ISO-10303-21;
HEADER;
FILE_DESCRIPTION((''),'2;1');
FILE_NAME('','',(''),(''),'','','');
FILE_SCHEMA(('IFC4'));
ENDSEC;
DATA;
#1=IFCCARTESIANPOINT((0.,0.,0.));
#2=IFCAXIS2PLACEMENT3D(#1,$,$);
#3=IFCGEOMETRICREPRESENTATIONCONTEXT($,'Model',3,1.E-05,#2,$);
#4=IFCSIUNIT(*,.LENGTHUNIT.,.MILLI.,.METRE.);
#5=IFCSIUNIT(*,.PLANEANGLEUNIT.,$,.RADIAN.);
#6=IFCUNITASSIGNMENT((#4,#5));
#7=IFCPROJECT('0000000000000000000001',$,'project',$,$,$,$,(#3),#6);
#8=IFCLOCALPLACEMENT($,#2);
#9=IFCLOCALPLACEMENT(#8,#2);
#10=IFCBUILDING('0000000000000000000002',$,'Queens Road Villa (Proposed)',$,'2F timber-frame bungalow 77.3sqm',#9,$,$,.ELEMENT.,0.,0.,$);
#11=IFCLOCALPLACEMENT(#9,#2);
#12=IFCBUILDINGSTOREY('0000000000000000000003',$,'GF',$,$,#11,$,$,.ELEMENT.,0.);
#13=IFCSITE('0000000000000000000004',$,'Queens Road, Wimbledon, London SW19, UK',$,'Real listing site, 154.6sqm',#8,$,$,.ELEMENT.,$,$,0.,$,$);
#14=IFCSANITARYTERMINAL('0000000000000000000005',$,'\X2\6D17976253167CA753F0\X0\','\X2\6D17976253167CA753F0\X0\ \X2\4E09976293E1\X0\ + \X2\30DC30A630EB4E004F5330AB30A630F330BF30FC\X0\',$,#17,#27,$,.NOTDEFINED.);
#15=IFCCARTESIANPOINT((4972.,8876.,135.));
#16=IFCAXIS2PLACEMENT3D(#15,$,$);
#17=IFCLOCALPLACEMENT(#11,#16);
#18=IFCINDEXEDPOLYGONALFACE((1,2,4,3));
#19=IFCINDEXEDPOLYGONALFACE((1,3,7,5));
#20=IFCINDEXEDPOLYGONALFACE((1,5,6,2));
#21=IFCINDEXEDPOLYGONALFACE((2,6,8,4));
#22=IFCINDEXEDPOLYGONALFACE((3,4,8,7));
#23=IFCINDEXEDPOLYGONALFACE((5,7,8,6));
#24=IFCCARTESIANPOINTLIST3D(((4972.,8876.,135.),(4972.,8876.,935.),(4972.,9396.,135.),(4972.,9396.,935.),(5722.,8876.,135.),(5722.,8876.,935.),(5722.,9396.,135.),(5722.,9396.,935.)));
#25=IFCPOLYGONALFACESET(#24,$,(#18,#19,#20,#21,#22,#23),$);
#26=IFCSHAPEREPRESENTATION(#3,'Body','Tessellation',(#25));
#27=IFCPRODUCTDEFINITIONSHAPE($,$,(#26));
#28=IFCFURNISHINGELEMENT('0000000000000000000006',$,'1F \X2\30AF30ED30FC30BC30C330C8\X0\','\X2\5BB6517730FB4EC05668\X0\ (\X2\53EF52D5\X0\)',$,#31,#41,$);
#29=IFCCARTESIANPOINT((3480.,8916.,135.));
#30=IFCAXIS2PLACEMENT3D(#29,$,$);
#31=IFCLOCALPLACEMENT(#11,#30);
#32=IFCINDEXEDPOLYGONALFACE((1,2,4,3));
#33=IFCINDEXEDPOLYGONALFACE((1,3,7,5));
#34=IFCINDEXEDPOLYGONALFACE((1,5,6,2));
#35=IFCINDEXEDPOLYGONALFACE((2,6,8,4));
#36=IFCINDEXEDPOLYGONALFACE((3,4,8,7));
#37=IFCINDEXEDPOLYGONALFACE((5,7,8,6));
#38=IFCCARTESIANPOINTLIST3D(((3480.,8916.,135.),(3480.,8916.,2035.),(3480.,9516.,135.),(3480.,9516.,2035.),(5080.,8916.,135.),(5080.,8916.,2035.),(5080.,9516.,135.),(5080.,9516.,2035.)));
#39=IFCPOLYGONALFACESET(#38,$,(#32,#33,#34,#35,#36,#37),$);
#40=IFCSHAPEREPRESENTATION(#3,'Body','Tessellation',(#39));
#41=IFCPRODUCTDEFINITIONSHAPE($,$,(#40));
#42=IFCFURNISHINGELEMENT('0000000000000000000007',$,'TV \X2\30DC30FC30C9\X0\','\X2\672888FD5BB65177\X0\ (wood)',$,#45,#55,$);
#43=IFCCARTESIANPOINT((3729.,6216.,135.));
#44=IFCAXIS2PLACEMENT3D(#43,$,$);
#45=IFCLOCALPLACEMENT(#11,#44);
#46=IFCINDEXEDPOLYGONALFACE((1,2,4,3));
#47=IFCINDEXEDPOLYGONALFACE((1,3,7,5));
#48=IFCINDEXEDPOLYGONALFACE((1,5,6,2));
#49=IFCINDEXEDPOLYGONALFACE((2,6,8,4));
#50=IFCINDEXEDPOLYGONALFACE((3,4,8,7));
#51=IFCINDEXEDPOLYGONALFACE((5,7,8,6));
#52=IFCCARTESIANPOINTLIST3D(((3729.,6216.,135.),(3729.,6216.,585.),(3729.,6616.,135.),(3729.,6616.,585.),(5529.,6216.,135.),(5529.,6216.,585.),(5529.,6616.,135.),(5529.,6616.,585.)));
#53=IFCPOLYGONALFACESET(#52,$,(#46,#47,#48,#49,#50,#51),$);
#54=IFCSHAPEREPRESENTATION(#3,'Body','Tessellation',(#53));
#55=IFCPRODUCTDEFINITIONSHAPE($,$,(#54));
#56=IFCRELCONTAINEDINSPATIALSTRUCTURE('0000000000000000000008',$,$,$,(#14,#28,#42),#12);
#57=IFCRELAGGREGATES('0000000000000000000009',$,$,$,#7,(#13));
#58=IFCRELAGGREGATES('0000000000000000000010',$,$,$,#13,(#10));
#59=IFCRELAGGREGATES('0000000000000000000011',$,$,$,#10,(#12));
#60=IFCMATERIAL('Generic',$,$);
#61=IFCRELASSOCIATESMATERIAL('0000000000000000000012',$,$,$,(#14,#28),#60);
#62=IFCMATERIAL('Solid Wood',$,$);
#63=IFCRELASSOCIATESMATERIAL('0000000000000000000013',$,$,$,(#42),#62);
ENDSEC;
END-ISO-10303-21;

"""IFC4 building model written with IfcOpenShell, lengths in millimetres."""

from ifc_helpers import new_model, si_unit, frame, frame_2d, origin, place, context, project, spatial, rectangle, extrude, material, element, save


model = new_model("IFC4")

# Units and contexts
model_context = context("Model", 3, precision=1e-05, world=origin())
ifc_project = project(units=[si_unit("LENGTHUNIT", "METRE", prefix="MILLI"), si_unit("PLANEANGLEUNIT", "RADIAN")], contexts=[model_context])

# Site, building, storey
site_placement = place(None, origin())
site = spatial("IfcSite", under=ifc_project, at=site_placement, Name="Queens Road, Wimbledon, London SW19, UK", ObjectType="Real listing site, 154.6sqm", CompositionType="ELEMENT", RefElevation=0.0)
building_placement = place(site_placement, origin())
building = spatial("IfcBuilding", under=site, at=building_placement, Name="Queens Road Villa (Proposed)", ObjectType="2F timber-frame bungalow 77.3sqm", CompositionType="ELEMENT", ElevationOfRefHeight=0.0, ElevationOfTerrain=0.0)
storey_placement = place(building_placement, origin())
storey = spatial("IfcBuildingStorey", under=building, at=storey_placement, Name="GF", CompositionType="ELEMENT", Elevation=0.0)

# Shared definitions
ifc_material_1 = material(Name="Solid Wood")

# Shared definitions
ifc_material_2 = material(Name="Generic")

# Sanitary terminal
sanitary_terminal_1_placement = place(storey_placement, frame((4972.0, 8876.0, 135.0)))
element("IfcSanitaryTerminal", 1, at=sanitary_terminal_1_placement, inside=storey, material=ifc_material_2, Name="洗面化粧台", Description="洗面化粧台 三面鏡 + ボウル一体カウンター", PredefinedType="NOTDEFINED", context=model_context, shape_type="SweptSolid", body=[
    extrude(rectangle(XDim=750.0, YDim=520.0, at=frame_2d((375.0, 260.0))), frame((4972.0, 8876.0, 135.0)), (0.0, 0.0, 1.0), 800.0),
])

# Furnishing elements
furnishing_1_placement = place(storey_placement, frame((3480.0, 8916.0, 135.0)))
element("IfcFurnishingElement", 2, at=furnishing_1_placement, inside=storey, material=ifc_material_2, Name="1F クローゼット", Description="家具・什器 (可動)", context=model_context, shape_type="SweptSolid", body=[
    extrude(rectangle(XDim=1600.0, YDim=600.0, at=frame_2d((800.0, 300.0))), frame((3480.0, 8916.0, 135.0)), (0.0, 0.0, 1.0), 1900.0),
])
furnishing_2_placement = place(storey_placement, frame((3729.0, 6216.0, 135.0)))
element("IfcFurnishingElement", 3, at=furnishing_2_placement, inside=storey, material=ifc_material_1, Name="TV ボード", Description="木製家具 (wood)", context=model_context, shape_type="SweptSolid", body=[
    extrude(rectangle(XDim=1800.0, YDim=400.0, at=frame_2d((900.0, 200.0))), frame((3729.0, 6216.0, 135.0)), (0.0, 0.0, 1.0), 450.0),
])

save(model, "model.ifc")
